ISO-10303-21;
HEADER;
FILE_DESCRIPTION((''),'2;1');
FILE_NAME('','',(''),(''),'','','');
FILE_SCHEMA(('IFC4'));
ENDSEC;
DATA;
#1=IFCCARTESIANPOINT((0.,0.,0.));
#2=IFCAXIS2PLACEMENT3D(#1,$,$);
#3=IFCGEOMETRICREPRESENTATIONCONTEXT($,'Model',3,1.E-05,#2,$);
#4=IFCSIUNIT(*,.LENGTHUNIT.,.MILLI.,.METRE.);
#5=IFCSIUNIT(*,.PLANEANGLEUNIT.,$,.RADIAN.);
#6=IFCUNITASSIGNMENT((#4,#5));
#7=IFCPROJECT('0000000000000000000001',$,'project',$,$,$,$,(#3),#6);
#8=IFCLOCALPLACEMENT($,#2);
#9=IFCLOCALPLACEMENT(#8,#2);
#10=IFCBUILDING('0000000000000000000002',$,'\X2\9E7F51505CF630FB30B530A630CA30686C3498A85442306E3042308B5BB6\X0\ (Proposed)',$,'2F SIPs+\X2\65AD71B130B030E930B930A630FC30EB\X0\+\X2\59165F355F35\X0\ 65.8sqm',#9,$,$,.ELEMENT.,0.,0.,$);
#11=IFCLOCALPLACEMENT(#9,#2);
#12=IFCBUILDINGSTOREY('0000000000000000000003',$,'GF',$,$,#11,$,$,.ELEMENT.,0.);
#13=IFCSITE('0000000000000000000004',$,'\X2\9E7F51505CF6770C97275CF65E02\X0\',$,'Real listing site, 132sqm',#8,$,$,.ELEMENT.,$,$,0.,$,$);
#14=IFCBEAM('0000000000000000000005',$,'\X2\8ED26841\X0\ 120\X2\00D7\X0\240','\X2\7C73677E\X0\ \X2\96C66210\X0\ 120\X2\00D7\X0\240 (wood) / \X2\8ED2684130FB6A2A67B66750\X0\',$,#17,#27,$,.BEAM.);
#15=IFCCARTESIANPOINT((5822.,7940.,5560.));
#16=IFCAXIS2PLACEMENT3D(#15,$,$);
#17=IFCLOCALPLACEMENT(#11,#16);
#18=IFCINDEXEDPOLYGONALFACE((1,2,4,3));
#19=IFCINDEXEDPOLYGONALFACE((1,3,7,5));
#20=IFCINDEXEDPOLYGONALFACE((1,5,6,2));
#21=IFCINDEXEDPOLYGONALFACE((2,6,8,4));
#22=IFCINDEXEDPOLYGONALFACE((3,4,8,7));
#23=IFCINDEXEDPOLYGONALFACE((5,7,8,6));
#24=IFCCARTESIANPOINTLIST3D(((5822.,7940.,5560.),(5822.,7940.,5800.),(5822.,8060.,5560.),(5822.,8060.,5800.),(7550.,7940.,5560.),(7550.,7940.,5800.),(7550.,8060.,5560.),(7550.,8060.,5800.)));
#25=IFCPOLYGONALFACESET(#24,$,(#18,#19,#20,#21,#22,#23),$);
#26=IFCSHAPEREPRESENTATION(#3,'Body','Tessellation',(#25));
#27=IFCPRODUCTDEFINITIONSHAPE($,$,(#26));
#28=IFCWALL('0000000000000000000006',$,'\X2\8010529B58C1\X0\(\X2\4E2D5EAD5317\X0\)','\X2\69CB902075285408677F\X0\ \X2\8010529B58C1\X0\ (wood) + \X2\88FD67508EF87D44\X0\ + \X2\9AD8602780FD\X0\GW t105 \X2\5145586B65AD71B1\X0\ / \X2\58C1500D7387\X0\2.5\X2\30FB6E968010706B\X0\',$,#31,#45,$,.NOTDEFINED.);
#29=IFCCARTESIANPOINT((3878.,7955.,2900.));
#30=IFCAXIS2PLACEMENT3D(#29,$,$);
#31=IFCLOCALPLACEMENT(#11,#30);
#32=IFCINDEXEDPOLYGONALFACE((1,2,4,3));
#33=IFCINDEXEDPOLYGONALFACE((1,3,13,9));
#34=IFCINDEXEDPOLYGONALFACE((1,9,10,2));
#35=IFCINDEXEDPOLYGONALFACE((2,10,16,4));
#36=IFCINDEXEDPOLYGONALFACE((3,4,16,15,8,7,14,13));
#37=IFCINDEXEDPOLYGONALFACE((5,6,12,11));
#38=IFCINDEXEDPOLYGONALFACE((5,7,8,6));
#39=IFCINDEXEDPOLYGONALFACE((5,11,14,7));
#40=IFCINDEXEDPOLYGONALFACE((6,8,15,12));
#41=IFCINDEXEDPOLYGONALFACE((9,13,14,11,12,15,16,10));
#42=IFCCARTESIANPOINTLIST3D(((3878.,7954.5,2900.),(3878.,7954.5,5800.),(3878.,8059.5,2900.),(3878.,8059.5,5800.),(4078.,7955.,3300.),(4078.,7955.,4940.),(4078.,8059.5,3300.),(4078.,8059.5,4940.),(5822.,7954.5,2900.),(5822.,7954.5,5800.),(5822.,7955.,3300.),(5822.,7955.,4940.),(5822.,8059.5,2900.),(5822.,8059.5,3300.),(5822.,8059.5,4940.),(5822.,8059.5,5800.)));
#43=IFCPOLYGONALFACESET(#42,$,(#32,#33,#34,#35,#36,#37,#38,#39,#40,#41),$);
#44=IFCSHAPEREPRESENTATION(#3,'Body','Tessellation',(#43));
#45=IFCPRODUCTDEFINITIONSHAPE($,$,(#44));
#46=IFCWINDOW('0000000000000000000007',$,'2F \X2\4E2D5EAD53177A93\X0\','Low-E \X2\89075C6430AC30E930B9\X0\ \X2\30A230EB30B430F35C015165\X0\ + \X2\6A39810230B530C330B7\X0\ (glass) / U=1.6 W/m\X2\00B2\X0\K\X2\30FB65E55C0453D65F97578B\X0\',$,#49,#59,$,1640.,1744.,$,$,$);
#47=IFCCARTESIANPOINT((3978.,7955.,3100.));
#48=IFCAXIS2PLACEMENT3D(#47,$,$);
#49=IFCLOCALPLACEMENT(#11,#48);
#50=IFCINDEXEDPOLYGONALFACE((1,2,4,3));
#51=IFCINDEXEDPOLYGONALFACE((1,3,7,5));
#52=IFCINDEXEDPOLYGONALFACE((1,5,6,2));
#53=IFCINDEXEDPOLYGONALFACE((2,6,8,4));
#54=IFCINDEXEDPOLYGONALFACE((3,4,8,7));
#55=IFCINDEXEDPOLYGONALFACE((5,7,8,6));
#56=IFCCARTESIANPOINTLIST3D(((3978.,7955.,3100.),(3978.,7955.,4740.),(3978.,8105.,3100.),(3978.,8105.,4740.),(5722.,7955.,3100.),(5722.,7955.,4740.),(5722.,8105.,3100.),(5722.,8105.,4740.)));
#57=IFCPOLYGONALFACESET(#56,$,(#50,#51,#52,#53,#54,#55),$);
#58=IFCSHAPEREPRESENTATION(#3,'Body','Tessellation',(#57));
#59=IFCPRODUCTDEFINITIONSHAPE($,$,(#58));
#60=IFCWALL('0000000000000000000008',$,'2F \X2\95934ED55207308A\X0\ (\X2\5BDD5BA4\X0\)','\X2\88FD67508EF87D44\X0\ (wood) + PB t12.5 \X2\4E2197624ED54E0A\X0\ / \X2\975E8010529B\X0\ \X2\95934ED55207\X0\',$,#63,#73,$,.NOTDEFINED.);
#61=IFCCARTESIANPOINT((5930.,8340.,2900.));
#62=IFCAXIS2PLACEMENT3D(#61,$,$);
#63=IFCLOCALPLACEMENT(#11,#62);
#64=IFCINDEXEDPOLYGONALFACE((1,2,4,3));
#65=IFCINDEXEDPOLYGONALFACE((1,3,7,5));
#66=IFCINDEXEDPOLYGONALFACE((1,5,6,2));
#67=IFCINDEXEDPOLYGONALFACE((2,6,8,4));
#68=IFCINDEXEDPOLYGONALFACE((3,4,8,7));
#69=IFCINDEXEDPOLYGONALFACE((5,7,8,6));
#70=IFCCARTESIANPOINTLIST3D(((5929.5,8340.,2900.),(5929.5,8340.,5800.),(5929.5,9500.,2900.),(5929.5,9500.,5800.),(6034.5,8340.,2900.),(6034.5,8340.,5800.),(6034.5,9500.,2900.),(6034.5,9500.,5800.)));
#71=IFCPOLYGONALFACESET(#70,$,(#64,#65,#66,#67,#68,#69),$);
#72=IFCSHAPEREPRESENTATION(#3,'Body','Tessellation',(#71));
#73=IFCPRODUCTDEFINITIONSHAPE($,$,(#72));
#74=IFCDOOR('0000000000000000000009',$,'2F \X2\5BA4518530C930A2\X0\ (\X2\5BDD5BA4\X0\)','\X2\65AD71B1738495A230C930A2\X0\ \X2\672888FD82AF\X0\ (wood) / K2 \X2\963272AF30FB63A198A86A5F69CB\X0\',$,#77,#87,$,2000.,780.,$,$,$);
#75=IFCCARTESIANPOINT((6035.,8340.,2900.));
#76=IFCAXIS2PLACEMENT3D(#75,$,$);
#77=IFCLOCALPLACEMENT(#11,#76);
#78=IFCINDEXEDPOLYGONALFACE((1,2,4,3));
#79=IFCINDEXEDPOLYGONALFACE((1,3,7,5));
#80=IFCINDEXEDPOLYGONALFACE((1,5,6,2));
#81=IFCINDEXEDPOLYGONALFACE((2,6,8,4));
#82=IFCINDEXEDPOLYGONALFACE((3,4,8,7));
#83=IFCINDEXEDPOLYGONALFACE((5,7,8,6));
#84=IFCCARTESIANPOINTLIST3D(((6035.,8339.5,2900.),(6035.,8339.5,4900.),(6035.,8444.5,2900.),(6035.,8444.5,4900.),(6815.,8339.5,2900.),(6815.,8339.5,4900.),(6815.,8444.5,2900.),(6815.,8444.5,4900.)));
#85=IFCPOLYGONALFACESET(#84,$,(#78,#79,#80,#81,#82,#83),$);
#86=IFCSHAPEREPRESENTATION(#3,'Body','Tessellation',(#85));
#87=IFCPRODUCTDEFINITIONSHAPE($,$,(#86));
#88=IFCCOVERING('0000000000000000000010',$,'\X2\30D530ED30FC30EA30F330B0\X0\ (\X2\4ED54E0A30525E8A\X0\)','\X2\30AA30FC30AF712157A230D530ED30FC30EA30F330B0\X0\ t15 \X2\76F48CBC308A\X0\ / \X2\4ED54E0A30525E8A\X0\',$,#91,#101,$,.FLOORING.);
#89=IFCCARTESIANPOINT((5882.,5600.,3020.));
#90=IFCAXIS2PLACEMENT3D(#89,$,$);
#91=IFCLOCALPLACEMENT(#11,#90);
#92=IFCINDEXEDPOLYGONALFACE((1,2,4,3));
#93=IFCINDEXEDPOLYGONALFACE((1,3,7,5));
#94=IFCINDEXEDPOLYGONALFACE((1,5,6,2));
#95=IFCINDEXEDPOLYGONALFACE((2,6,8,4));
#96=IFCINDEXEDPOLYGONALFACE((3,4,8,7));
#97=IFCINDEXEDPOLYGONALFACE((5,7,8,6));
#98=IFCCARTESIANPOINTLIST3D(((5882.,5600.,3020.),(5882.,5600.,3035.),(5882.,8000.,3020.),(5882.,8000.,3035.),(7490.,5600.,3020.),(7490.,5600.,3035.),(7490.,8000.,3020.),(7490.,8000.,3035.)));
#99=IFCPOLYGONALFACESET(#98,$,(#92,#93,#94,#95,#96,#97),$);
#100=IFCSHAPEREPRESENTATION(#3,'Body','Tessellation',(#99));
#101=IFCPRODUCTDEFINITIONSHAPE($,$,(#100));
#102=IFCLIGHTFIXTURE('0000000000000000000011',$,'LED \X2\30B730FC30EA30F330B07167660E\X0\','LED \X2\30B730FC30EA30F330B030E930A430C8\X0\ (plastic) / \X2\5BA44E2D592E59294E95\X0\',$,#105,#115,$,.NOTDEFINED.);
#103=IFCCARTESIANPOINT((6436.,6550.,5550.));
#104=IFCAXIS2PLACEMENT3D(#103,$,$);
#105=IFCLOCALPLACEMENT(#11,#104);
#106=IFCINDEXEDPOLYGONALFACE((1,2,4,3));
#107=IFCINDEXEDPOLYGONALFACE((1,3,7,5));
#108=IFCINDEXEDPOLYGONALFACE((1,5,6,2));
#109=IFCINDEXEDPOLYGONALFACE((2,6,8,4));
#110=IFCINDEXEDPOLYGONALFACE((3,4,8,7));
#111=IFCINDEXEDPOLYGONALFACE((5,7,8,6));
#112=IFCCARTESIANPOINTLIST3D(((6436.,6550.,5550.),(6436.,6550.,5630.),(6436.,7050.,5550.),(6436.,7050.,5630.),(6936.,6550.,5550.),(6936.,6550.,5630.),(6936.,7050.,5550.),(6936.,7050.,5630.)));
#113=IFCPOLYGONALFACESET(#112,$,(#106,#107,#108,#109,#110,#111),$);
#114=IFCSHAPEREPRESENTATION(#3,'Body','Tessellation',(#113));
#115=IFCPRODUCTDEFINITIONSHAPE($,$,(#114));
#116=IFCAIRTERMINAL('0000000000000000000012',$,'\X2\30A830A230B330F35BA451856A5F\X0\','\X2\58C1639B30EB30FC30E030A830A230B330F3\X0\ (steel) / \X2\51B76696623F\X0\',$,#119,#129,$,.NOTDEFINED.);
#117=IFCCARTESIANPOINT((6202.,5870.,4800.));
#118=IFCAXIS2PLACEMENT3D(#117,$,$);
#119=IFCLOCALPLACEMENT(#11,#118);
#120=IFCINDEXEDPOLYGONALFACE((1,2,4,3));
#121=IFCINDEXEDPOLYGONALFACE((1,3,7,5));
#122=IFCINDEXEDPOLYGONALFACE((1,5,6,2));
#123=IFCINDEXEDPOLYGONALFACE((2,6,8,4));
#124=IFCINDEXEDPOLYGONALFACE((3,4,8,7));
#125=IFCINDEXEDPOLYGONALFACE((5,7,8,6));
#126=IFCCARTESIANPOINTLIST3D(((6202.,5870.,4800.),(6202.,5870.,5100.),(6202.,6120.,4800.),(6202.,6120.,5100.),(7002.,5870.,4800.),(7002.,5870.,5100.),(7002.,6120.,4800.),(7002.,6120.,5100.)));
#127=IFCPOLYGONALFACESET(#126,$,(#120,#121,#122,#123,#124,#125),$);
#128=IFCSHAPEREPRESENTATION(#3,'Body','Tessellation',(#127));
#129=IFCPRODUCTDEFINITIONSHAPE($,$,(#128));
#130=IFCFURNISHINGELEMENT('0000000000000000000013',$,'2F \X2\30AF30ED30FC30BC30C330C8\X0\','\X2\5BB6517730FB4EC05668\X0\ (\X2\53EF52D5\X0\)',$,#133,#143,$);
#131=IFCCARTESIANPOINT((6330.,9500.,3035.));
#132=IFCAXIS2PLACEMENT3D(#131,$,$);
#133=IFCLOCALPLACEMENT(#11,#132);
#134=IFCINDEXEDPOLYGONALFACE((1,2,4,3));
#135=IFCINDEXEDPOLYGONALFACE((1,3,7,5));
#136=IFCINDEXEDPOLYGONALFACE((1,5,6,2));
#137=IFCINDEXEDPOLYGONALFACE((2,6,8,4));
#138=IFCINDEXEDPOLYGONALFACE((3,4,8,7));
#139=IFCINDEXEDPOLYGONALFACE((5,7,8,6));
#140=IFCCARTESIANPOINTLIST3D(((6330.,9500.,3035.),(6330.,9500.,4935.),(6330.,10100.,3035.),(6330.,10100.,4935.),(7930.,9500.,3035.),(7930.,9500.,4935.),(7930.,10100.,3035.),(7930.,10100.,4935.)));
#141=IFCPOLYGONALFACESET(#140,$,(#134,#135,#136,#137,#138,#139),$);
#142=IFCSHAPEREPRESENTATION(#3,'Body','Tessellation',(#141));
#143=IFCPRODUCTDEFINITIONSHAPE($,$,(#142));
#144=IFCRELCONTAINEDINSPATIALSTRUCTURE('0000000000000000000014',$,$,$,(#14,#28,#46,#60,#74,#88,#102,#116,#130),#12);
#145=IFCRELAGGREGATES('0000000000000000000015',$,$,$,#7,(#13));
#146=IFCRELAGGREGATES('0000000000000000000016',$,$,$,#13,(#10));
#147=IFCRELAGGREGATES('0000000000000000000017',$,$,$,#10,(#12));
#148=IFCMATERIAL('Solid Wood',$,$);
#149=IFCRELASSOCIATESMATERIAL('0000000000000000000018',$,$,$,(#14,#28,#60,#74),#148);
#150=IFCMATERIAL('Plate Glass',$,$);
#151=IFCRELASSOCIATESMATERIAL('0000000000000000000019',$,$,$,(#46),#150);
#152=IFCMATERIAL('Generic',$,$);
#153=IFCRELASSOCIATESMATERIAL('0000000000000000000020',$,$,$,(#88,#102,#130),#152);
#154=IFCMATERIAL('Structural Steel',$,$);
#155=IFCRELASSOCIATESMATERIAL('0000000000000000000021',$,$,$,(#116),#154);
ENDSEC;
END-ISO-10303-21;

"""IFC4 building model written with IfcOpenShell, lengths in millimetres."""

from ifc_helpers import new_model, si_unit, frame, frame_2d, origin, place, context, project, spatial, rectangle, extrude, material, element, fill, save


model = new_model("IFC4")

# Units and contexts
model_context = context("Model", 3, precision=1e-05, world=origin())
ifc_project = project(units=[si_unit("LENGTHUNIT", "METRE", prefix="MILLI"), si_unit("PLANEANGLEUNIT", "RADIAN")], contexts=[model_context])

# Site, building, storey
site_placement = place(None, origin())
site = spatial("IfcSite", under=ifc_project, at=site_placement, Name="鹿児島県霧島市", ObjectType="Real listing site, 132sqm", CompositionType="ELEMENT", RefElevation=0.0)
building_placement = place(site_placement, origin())
building = spatial("IfcBuilding", under=site, at=building_placement, Name="鹿児島・サウナと水風呂のある家 (Proposed)", ObjectType="2F SIPs+断熱グラスウール+外張張 65.8sqm", CompositionType="ELEMENT", ElevationOfRefHeight=0.0, ElevationOfTerrain=0.0)
storey_placement = place(building_placement, origin())
storey = spatial("IfcBuildingStorey", under=building, at=storey_placement, Name="GF", CompositionType="ELEMENT", Elevation=0.0)

# Shared definitions
ifc_material_1 = material(Name="Solid Wood")

# Beam
beam_1_placement = place(storey_placement, frame((5822.0, 7940.0, 5560.0)))
element("IfcBeam", 1, at=beam_1_placement, inside=storey, material=ifc_material_1, Name="軒桁 120×240", Description="米松 集成 120×240 (wood) / 軒桁・横架材", PredefinedType="BEAM", context=model_context, shape_type="SweptSolid", body=[
    extrude(rectangle(XDim=1728.0, YDim=120.0, at=frame_2d((864.0, 60.0))), frame((5822.0, 7940.0, 5560.0)), (0.0, 0.0, 1.0), 240.0),
])

# Wall, opening, window
wall_1_placement = place(storey_placement, frame((3878.0, 7955.0, 2900.0)))
wall_1 = element("IfcWall", 2, at=wall_1_placement, inside=storey, material=ifc_material_1, Name="耐力壁(中庭北)", Description="構造用合板 耐力壁 (wood) + 製材軸組 + 高性能GW t105 充填断熱 / 壁倍率2.5・準耐火", PredefinedType="NOTDEFINED", context=model_context, shape_type="SweptSolid", body=[
    extrude(rectangle(XDim=1944.0, YDim=105.0, at=frame_2d((972.0, 52.0))), frame((3878.0, 7955.0, 2900.0)), (0.0, 0.0, 1.0), 2900.0),
])
opening_placement = place(storey_placement, frame((3978.0, 7955.0, 3100.0)))
opening = element("IfcOpeningElement", 3, at=opening_placement, cuts=wall_1, PredefinedType="NOTDEFINED", context=model_context, shape_type="SweptSolid", body=[
    extrude(rectangle(XDim=1744.0, YDim=150.0, at=frame_2d((872.0, 75.0))), frame((3978.0, 7955.0, 3100.0)), (0.0, 0.0, 1.0), 1640.0),
])
ifc_material_2 = material(Name="Plate Glass")
window_placement = place(storey_placement, frame((3978.0, 7955.0, 3100.0)))
window = element("IfcWindow", 4, at=window_placement, inside=storey, material=ifc_material_2, Name="2F 中庭北窓", Description="Low-E 複層ガラス アルゴン封入 + 樹脂サッシ (glass) / U=1.6 W/m²K・日射取得型", OverallHeight=1640.0, OverallWidth=1744.0, context=model_context, shape_type="SweptSolid", body=[
    extrude(rectangle(XDim=1744.0, YDim=150.0, at=frame_2d((872.0, 75.0))), frame((3978.0, 7955.0, 3100.0)), (0.0, 0.0, 1.0), 1640.0),
])
fill(opening, window)

# Wall
wall_2_placement = place(storey_placement, frame((5930.0, 8340.0, 2900.0)))
element("IfcWall", 5, at=wall_2_placement, inside=storey, material=ifc_material_1, Name="2F 間仕切り (寝室)", Description="製材軸組 (wood) + PB t12.5 両面仕上 / 非耐力 間仕切", PredefinedType="NOTDEFINED", context=model_context, shape_type="SweptSolid", body=[
    extrude(rectangle(XDim=105.0, YDim=1160.0, at=frame_2d((52.0, 580.0))), frame((5930.0, 8340.0, 2900.0)), (0.0, 0.0, 1.0), 2900.0),
])

# Door
door_placement = place(storey_placement, frame((6035.0, 8340.0, 2900.0)))
element("IfcDoor", 6, at=door_placement, inside=storey, material=ifc_material_1, Name="2F 室内ドア (寝室)", Description="断熱玄関ドア 木製芯 (wood) / K2 防犯・採風機構", OverallHeight=2000.0, OverallWidth=780.0, context=model_context, shape_type="SweptSolid", body=[
    extrude(rectangle(XDim=780.0, YDim=105.0, at=frame_2d((390.0, 52.0))), frame((6035.0, 8340.0, 2900.0)), (0.0, 0.0, 1.0), 2000.0),
])

# Covering
ifc_material_3 = material(Name="Generic")
covering_placement = place(storey_placement, frame((5882.0, 5600.0, 3020.0)))
element("IfcCovering", 7, at=covering_placement, inside=storey, material=ifc_material_3, Name="フローリング (仕上げ床)", Description="オーク無垢フローリング t15 直貼り / 仕上げ床", PredefinedType="FLOORING", context=model_context, shape_type="SweptSolid", body=[
    extrude(rectangle(XDim=1608.0, YDim=2400.0, at=frame_2d((804.0, 1200.0))), frame((5882.0, 5600.0, 3020.0)), (0.0, 0.0, 1.0), 15.0),
])

# Light fixture
light_fixture_placement = place(storey_placement, frame((6436.0, 6550.0, 5550.0)))
element("IfcLightFixture", 8, at=light_fixture_placement, inside=storey, material=ifc_material_3, Name="LED シーリング照明", Description="LED シーリングライト (plastic) / 室中央天井", PredefinedType="NOTDEFINED", context=model_context, shape_type="SweptSolid", body=[
    extrude(rectangle(XDim=500.0, YDim=500.0, at=frame_2d((250.0, 250.0))), frame((6436.0, 6550.0, 5550.0)), (0.0, 0.0, 1.0), 80.0),
])

# Air terminal
ifc_material_4 = material(Name="Structural Steel")
air_terminal_placement = place(storey_placement, frame((6202.0, 5870.0, 4800.0)))
element("IfcAirTerminal", 9, at=air_terminal_placement, inside=storey, material=ifc_material_4, Name="エアコン室内機", Description="壁掛ルームエアコン (steel) / 冷暖房", PredefinedType="NOTDEFINED", context=model_context, shape_type="SweptSolid", body=[
    extrude(rectangle(XDim=800.0, YDim=250.0, at=frame_2d((400.0, 125.0))), frame((6202.0, 5870.0, 4800.0)), (0.0, 0.0, 1.0), 300.0),
])

# Furnishing element
furnishing_placement = place(storey_placement, frame((6330.0, 9500.0, 3035.0)))
element("IfcFurnishingElement", 10, at=furnishing_placement, inside=storey, material=ifc_material_3, Name="2F クローゼット", Description="家具・什器 (可動)", context=model_context, shape_type="SweptSolid", body=[
    extrude(rectangle(XDim=1600.0, YDim=600.0, at=frame_2d((800.0, 300.0))), frame((6330.0, 9500.0, 3035.0)), (0.0, 0.0, 1.0), 1900.0),
])

save(model, "model.ifc")
